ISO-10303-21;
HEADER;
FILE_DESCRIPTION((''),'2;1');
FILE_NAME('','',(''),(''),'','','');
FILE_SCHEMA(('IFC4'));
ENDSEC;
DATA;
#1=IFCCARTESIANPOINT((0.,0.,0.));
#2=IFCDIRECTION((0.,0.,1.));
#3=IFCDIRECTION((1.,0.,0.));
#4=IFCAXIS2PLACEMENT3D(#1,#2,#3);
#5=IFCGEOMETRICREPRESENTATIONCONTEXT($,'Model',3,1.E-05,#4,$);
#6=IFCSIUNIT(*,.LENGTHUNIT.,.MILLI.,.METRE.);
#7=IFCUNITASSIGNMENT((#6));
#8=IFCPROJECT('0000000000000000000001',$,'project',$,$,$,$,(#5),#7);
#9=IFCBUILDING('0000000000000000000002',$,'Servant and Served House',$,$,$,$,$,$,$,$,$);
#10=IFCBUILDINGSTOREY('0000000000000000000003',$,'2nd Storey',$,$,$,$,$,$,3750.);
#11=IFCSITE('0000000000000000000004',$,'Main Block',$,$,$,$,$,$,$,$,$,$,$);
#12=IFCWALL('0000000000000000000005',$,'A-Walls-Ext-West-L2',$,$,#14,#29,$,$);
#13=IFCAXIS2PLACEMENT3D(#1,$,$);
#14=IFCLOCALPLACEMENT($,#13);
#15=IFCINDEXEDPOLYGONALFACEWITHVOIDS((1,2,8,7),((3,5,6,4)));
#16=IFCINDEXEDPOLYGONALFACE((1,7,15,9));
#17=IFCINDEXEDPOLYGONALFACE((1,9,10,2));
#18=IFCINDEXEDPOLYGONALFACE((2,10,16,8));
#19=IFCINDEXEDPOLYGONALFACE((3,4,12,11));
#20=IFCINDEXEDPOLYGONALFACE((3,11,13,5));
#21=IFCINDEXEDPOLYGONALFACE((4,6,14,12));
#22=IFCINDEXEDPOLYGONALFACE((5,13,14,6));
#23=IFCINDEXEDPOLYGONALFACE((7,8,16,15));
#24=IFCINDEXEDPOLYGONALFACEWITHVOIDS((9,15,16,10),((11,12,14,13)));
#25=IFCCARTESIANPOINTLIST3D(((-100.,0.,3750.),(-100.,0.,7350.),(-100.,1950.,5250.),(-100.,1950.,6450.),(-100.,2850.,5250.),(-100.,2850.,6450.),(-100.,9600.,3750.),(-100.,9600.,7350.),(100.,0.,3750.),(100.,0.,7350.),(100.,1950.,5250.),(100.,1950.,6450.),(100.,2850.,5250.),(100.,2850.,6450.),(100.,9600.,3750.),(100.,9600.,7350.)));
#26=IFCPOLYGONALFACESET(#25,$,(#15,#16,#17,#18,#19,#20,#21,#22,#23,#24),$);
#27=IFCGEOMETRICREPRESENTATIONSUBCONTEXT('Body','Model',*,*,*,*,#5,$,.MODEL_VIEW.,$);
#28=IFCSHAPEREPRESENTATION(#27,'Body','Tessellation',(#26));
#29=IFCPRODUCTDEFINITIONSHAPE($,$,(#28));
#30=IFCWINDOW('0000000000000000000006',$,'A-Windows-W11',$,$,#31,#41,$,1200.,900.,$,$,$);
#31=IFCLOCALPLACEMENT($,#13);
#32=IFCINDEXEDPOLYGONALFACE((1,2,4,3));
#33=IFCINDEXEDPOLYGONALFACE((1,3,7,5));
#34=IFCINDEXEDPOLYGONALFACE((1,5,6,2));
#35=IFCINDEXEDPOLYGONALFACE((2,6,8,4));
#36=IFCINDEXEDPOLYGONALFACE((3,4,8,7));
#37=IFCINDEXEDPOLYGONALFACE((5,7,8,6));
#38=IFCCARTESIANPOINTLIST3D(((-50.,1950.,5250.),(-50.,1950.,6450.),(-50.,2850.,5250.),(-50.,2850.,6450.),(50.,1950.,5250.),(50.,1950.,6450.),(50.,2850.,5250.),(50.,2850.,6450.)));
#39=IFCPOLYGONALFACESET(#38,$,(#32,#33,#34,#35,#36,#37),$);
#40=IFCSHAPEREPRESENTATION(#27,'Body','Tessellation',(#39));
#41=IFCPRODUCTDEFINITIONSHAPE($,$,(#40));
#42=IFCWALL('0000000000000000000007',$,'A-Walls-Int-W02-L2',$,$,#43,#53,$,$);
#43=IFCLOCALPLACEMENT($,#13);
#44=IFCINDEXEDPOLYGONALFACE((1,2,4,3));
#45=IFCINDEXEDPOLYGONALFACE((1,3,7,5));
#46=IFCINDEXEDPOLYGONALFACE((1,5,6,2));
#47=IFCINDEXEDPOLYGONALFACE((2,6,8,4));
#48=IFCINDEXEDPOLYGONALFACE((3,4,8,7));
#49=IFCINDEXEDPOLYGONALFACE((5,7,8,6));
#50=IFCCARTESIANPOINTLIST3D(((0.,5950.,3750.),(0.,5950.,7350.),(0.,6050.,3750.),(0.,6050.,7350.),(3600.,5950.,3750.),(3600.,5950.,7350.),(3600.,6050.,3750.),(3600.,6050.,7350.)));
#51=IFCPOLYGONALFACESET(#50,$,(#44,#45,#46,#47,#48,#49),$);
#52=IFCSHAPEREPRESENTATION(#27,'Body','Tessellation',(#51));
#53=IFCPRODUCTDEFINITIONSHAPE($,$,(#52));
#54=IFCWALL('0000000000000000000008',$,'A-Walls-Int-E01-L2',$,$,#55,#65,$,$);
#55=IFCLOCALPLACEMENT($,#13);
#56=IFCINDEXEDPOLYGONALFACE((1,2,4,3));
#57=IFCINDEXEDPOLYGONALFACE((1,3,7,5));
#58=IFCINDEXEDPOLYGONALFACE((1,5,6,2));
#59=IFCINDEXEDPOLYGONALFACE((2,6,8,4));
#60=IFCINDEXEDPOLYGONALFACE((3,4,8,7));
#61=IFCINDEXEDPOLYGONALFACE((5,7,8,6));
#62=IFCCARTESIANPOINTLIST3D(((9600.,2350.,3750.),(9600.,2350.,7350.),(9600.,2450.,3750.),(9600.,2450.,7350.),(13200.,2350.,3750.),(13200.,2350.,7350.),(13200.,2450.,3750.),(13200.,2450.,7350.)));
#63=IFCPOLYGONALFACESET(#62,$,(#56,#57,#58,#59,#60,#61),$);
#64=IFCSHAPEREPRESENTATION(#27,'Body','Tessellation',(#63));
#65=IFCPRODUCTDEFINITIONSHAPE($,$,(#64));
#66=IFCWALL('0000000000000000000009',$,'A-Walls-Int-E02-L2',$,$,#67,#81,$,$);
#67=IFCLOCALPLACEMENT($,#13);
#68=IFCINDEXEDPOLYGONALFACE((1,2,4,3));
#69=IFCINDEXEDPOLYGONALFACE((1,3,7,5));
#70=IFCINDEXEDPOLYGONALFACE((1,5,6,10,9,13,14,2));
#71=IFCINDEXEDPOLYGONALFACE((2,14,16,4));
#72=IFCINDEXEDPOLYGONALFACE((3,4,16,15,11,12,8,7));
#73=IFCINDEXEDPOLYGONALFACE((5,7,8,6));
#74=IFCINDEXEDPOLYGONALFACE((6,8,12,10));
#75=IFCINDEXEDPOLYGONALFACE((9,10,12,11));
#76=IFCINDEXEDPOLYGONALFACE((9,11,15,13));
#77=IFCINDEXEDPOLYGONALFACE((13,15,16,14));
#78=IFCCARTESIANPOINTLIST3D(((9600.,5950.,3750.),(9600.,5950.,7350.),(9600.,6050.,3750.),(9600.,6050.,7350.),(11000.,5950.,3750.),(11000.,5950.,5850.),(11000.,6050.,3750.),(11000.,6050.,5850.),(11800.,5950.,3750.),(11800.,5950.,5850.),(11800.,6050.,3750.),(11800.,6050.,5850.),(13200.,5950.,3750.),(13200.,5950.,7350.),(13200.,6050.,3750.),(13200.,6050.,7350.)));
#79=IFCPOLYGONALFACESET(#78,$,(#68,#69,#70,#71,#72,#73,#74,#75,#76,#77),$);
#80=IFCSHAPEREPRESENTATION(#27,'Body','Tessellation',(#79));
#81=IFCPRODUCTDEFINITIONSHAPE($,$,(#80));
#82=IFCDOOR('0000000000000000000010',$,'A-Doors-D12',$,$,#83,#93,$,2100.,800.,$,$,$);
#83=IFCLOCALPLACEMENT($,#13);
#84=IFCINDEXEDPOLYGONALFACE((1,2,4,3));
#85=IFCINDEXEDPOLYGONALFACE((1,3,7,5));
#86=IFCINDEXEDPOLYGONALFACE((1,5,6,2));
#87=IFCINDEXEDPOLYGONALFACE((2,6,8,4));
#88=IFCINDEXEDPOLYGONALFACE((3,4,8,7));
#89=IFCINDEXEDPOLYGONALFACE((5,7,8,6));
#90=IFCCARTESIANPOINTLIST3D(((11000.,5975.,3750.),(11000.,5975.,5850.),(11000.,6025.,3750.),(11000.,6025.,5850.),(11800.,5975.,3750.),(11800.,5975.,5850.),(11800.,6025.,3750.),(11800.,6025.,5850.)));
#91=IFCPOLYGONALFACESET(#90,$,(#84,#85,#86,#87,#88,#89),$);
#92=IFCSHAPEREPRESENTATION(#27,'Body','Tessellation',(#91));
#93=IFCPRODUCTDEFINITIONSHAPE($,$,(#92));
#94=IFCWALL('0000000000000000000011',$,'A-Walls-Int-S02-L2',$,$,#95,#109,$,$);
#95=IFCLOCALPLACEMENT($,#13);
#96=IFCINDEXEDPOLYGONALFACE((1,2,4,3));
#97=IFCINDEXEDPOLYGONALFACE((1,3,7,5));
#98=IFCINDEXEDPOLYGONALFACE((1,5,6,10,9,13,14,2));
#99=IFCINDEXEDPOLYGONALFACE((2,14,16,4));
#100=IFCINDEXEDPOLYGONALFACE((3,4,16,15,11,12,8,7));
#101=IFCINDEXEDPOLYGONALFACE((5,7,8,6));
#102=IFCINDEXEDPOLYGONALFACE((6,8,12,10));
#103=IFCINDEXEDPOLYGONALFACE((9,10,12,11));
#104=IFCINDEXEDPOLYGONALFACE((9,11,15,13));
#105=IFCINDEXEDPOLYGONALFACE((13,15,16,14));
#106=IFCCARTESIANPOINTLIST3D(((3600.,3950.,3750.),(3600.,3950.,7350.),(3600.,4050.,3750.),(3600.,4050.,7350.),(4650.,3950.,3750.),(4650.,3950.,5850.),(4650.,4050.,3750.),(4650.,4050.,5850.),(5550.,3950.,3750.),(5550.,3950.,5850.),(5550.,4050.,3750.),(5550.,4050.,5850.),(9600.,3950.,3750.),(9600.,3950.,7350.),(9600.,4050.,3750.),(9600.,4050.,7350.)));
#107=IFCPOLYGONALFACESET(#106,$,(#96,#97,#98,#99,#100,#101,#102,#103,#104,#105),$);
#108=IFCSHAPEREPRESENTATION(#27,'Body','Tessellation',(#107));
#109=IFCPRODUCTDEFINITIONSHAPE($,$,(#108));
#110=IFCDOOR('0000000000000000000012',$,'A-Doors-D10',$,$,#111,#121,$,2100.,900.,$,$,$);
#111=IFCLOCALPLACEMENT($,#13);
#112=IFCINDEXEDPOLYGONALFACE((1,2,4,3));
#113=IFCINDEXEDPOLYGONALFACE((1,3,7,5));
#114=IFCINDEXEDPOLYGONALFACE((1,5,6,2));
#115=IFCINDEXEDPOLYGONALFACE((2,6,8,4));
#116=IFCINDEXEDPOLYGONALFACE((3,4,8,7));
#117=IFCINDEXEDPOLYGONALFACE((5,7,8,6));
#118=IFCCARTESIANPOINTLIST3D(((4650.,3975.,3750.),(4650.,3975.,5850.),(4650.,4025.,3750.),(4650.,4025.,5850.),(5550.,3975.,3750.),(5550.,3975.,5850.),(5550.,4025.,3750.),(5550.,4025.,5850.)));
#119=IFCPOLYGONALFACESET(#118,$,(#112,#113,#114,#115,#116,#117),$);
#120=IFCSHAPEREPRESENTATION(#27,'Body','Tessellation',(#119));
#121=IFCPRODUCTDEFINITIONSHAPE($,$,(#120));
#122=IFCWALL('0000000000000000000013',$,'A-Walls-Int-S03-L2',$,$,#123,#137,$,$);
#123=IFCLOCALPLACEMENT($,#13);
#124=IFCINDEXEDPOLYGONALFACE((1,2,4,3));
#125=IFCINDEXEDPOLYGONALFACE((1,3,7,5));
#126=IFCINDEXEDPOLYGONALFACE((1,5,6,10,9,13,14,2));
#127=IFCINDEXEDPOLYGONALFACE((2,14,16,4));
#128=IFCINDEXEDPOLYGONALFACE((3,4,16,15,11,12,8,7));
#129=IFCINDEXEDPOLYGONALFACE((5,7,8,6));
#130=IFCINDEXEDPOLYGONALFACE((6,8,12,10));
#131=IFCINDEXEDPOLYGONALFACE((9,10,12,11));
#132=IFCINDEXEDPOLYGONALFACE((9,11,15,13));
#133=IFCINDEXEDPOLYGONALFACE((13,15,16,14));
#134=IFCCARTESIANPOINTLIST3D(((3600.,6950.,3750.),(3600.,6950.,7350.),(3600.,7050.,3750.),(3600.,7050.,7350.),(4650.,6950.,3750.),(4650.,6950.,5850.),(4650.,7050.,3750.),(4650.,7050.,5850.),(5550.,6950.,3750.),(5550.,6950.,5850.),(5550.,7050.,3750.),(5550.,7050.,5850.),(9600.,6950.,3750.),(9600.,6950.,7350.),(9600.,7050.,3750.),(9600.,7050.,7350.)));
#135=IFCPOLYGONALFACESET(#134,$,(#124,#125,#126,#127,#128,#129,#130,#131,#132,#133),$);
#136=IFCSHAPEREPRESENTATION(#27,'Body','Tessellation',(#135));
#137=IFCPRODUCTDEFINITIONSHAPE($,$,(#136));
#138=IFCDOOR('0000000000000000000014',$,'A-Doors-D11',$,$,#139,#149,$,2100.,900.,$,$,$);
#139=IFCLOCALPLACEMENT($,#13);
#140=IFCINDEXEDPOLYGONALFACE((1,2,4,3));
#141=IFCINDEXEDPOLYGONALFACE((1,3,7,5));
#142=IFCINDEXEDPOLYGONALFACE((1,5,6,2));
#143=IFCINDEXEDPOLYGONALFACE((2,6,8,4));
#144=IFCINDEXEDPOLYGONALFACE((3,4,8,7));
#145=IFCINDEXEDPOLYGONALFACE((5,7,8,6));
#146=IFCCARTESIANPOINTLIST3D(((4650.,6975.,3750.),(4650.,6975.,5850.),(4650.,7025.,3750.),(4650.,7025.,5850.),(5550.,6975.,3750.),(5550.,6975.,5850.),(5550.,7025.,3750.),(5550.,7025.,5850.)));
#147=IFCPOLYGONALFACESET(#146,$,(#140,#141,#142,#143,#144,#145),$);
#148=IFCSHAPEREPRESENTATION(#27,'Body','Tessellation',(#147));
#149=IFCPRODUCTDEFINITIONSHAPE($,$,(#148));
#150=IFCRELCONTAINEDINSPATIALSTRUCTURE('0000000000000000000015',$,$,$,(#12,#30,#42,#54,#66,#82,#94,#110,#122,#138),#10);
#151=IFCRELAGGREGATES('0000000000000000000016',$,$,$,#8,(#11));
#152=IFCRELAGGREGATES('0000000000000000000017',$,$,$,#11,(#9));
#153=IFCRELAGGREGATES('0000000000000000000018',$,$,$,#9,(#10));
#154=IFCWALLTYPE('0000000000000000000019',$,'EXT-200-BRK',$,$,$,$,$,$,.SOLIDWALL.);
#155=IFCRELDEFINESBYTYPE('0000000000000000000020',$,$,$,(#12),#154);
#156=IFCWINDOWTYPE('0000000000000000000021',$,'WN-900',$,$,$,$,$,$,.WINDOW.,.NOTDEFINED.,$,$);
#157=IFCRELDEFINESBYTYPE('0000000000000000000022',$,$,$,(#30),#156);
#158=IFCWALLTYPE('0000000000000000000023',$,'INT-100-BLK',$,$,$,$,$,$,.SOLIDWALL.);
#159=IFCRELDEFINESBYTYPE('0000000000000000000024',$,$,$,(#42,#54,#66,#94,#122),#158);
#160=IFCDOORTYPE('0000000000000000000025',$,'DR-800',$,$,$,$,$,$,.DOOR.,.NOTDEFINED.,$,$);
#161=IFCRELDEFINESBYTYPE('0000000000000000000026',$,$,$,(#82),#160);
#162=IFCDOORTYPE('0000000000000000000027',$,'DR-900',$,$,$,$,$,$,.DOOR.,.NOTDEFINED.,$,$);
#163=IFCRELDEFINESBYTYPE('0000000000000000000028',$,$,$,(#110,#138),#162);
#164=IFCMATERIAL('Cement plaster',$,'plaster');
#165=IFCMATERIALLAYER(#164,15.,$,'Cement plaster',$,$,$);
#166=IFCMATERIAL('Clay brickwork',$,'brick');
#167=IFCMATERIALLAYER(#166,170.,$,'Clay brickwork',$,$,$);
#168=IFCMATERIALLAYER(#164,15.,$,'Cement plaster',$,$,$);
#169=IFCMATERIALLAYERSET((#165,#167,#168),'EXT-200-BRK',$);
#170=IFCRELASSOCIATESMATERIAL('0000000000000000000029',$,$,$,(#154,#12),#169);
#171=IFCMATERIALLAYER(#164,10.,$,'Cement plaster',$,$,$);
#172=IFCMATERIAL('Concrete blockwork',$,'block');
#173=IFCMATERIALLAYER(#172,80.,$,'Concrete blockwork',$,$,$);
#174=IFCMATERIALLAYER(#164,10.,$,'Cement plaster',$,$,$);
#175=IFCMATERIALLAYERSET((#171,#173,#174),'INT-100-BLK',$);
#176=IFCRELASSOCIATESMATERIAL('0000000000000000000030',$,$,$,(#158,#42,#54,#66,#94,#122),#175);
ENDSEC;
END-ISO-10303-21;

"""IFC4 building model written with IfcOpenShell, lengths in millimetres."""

from ifc_helpers import new_model, si_unit, frame, origin_with_axes, place, context, subcontext, project, spatial, indexed_curve, outline, extrude, material, layer, layer_set, layer_usage, type_object, element, fill, save


model = new_model("IFC4")

# Units and contexts
model_context = context("Model", 3, precision=1e-05, world=origin_with_axes())
body_context = subcontext(model_context, "Body", "Model", "MODEL_VIEW")
ifc_project = project(units=[si_unit("LENGTHUNIT", "METRE", prefix="MILLI")], contexts=[model_context])

# Site, building, storey
site = spatial("IfcSite", under=ifc_project, Name="Main Block")
building = spatial("IfcBuilding", under=site, Name="Servant and Served House")
storey = spatial("IfcBuildingStorey", under=building, Name="2nd Storey", Elevation=3750.0)

# Shared definitions
ifc_material_1 = material(Name="Cement plaster", Category="plaster")
ifc_layer_1 = layer(ifc_material_1, 15.0, Name="Cement plaster")
ifc_material_2 = material(Name="Clay brickwork", Category="brick")
ifc_layer_2 = layer(ifc_material_2, 170.0, Name="Clay brickwork")
ifc_layer_3 = layer(ifc_material_1, 15.0, Name="Cement plaster")
ifc_layer_set_1 = layer_set([ifc_layer_1, ifc_layer_2, ifc_layer_3], Name="EXT-200-BRK")
wall_type_1 = type_object("IfcWallType", Name="EXT-200-BRK", PredefinedType="SOLIDWALL", material=ifc_layer_set_1)

# Shared definitions
window_type_1 = type_object("IfcWindowType", Name="WN-900", PartitioningType="NOTDEFINED", PredefinedType="WINDOW")

# Wall, opening, window
ifc_layer_usage_1 = layer_usage(ifc_layer_set_1, "AXIS2", "POSITIVE", 0.0)
wall_1_placement = place(None, frame((-100.0, 9600.0, 3750.0), z_axis=(0.0, 0.0, 1.0), x_axis=(0.0, -1.0, 0.0)))
wall_1 = element("IfcWall", 1, at=wall_1_placement, inside=storey, type_object=wall_type_1, material=ifc_layer_usage_1, Name="A-Walls-Ext-West-L2", context=body_context, shape_type="SweptSolid", body=[
    extrude(outline(indexed_curve([(0.0, 0.0), (0.0, 200.0), (9600.0, 200.0), (9600.0, 0.0), (0.0, 0.0)], self_intersect=False)), origin_with_axes(), (0.0, 0.0, 1.0), 3600.0),
])
opening_1_placement = place(wall_1_placement, frame((7200.0, 100.0, 1500.0), z_axis=(0.0, 0.0, 1.0), x_axis=(1.0, 0.0, 0.0)))
opening_1 = element("IfcOpeningElement", 2, at=opening_1_placement, cuts=wall_1, PredefinedType="OPENING", context=body_context, shape_type="SweptSolid", body=[
    extrude(outline(indexed_curve([(-450.0, -150.0), (450.0, -150.0), (450.0, 150.0), (-450.0, 150.0)])), None, (0.0, 0.0, 1.0), 1200.0),
])
window_1_placement = place(None, frame((0.0, 2400.0, 5250.0), z_axis=(0.0, 0.0, 1.0), x_axis=(0.0, -1.0, 0.0)))
window_1 = element("IfcWindow", 3, at=window_1_placement, inside=storey, type_object=window_type_1, Name="A-Windows-W11", OverallHeight=1200.0, OverallWidth=900.0, context=body_context, shape_type="SweptSolid", body=[
    extrude(outline(indexed_curve([(-450.0, -50.0), (450.0, -50.0), (450.0, 50.0), (-450.0, 50.0)])), None, (0.0, 0.0, 1.0), 1200.0),
])
fill(opening_1, window_1)

# Walls
ifc_layer_4 = layer(ifc_material_1, 10.0, Name="Cement plaster")
ifc_material_3 = material(Name="Concrete blockwork", Category="block")
ifc_layer_5 = layer(ifc_material_3, 80.0, Name="Concrete blockwork")
ifc_layer_6 = layer(ifc_material_1, 10.0, Name="Cement plaster")
ifc_layer_set_2 = layer_set([ifc_layer_4, ifc_layer_5, ifc_layer_6], Name="INT-100-BLK")
ifc_layer_usage_2 = layer_usage(ifc_layer_set_2, "AXIS2", "POSITIVE", 0.0)
wall_type_2 = type_object("IfcWallType", Name="INT-100-BLK", PredefinedType="SOLIDWALL", material=ifc_layer_set_2)
wall_2_placement = place(None, frame((0.0, 5950.0, 3750.0), z_axis=(0.0, 0.0, 1.0), x_axis=(1.0, 0.0, 0.0)))
element("IfcWall", 4, at=wall_2_placement, inside=storey, type_object=wall_type_2, material=ifc_layer_usage_2, Name="A-Walls-Int-W02-L2", context=body_context, shape_type="SweptSolid", body=[
    extrude(outline(indexed_curve([(0.0, 0.0), (0.0, 100.0), (3600.0, 100.0), (3600.0, 0.0), (0.0, 0.0)], self_intersect=False)), origin_with_axes(), (0.0, 0.0, 1.0), 3600.0),
])
ifc_layer_usage_3 = layer_usage(ifc_layer_set_2, "AXIS2", "POSITIVE", 0.0)
wall_3_placement = place(None, frame((9600.0, 2350.0, 3750.0), z_axis=(0.0, 0.0, 1.0), x_axis=(1.0, 0.0, 0.0)))
element("IfcWall", 5, at=wall_3_placement, inside=storey, type_object=wall_type_2, material=ifc_layer_usage_3, Name="A-Walls-Int-E01-L2", context=body_context, shape_type="SweptSolid", body=[
    extrude(outline(indexed_curve([(0.0, 0.0), (0.0, 100.0), (3600.0, 100.0), (3600.0, 0.0), (0.0, 0.0)], self_intersect=False)), origin_with_axes(), (0.0, 0.0, 1.0), 3600.0),
])

# Walls, openings, doors
ifc_layer_usage_4 = layer_usage(ifc_layer_set_2, "AXIS2", "POSITIVE", 0.0)
wall_4_placement = place(None, frame((9600.0, 5950.0, 3750.0), z_axis=(0.0, 0.0, 1.0), x_axis=(1.0, 0.0, 0.0)))
wall_4 = element("IfcWall", 6, at=wall_4_placement, inside=storey, type_object=wall_type_2, material=ifc_layer_usage_4, Name="A-Walls-Int-E02-L2", context=body_context, shape_type="SweptSolid", body=[
    extrude(outline(indexed_curve([(0.0, 0.0), (0.0, 100.0), (3600.0, 100.0), (3600.0, 0.0), (0.0, 0.0)], self_intersect=False)), origin_with_axes(), (0.0, 0.0, 1.0), 3600.0),
])
opening_2_placement = place(wall_4_placement, frame((1800.0, 50.0, 0.0), z_axis=(0.0, 0.0, 1.0), x_axis=(1.0, 0.0, 0.0)))
opening_2 = element("IfcOpeningElement", 7, at=opening_2_placement, cuts=wall_4, PredefinedType="OPENING", context=body_context, shape_type="SweptSolid", body=[
    extrude(outline(indexed_curve([(-400.0, -100.0), (400.0, -100.0), (400.0, 100.0), (-400.0, 100.0)])), None, (0.0, 0.0, 1.0), 2100.0),
])
door_type_1 = type_object("IfcDoorType", Name="DR-800", OperationType="NOTDEFINED", PredefinedType="DOOR")
door_1_placement = place(None, frame((11400.0, 6000.0, 3750.0), z_axis=(0.0, 0.0, 1.0), x_axis=(1.0, 0.0, 0.0)))
door_1 = element("IfcDoor", 8, at=door_1_placement, inside=storey, type_object=door_type_1, Name="A-Doors-D12", OverallHeight=2100.0, OverallWidth=800.0, context=body_context, shape_type="SweptSolid", body=[
    extrude(outline(indexed_curve([(-400.0, -25.0), (400.0, -25.0), (400.0, 25.0), (-400.0, 25.0)])), None, (0.0, 0.0, 1.0), 2100.0),
])
fill(opening_2, door_1)
ifc_layer_usage_5 = layer_usage(ifc_layer_set_2, "AXIS2", "POSITIVE", 0.0)
wall_5_placement = place(None, frame((3600.0, 3950.0, 3750.0), z_axis=(0.0, 0.0, 1.0), x_axis=(1.0, 0.0, 0.0)))
wall_5 = element("IfcWall", 9, at=wall_5_placement, inside=storey, type_object=wall_type_2, material=ifc_layer_usage_5, Name="A-Walls-Int-S02-L2", context=body_context, shape_type="SweptSolid", body=[
    extrude(outline(indexed_curve([(0.0, 0.0), (0.0, 100.0), (6000.0, 100.0), (6000.0, 0.0), (0.0, 0.0)], self_intersect=False)), origin_with_axes(), (0.0, 0.0, 1.0), 3600.0),
])
opening_3_placement = place(wall_5_placement, frame((1500.0, 50.0, 0.0), z_axis=(0.0, 0.0, 1.0), x_axis=(1.0, 0.0, 0.0)))
opening_3 = element("IfcOpeningElement", 10, at=opening_3_placement, cuts=wall_5, PredefinedType="OPENING", context=body_context, shape_type="SweptSolid", body=[
    extrude(outline(indexed_curve([(-450.0, -100.0), (450.0, -100.0), (450.0, 100.0), (-450.0, 100.0)])), None, (0.0, 0.0, 1.0), 2100.0),
])
door_type_2 = type_object("IfcDoorType", Name="DR-900", OperationType="NOTDEFINED", PredefinedType="DOOR")
door_2_placement = place(None, frame((5100.0, 4000.0, 3750.0), z_axis=(0.0, 0.0, 1.0), x_axis=(1.0, 0.0, 0.0)))
door_2 = element("IfcDoor", 11, at=door_2_placement, inside=storey, type_object=door_type_2, Name="A-Doors-D10", OverallHeight=2100.0, OverallWidth=900.0, context=body_context, shape_type="SweptSolid", body=[
    extrude(outline(indexed_curve([(-450.0, -25.0), (450.0, -25.0), (450.0, 25.0), (-450.0, 25.0)])), None, (0.0, 0.0, 1.0), 2100.0),
])
fill(opening_3, door_2)
ifc_layer_usage_6 = layer_usage(ifc_layer_set_2, "AXIS2", "POSITIVE", 0.0)
wall_6_placement = place(None, frame((3600.0, 6950.0, 3750.0), z_axis=(0.0, 0.0, 1.0), x_axis=(1.0, 0.0, 0.0)))
wall_6 = element("IfcWall", 12, at=wall_6_placement, inside=storey, type_object=wall_type_2, material=ifc_layer_usage_6, Name="A-Walls-Int-S03-L2", context=body_context, shape_type="SweptSolid", body=[
    extrude(outline(indexed_curve([(0.0, 0.0), (0.0, 100.0), (6000.0, 100.0), (6000.0, 0.0), (0.0, 0.0)], self_intersect=False)), origin_with_axes(), (0.0, 0.0, 1.0), 3600.0),
])
opening_4_placement = place(wall_6_placement, frame((1500.0, 50.0, 0.0), z_axis=(0.0, 0.0, 1.0), x_axis=(1.0, 0.0, 0.0)))
opening_4 = element("IfcOpeningElement", 13, at=opening_4_placement, cuts=wall_6, PredefinedType="OPENING", context=body_context, shape_type="SweptSolid", body=[
    extrude(outline(indexed_curve([(-450.0, -100.0), (450.0, -100.0), (450.0, 100.0), (-450.0, 100.0)])), None, (0.0, 0.0, 1.0), 2100.0),
])
door_3_placement = place(None, frame((5100.0, 7000.0, 3750.0), z_axis=(0.0, 0.0, 1.0), x_axis=(1.0, 0.0, 0.0)))
door_3 = element("IfcDoor", 14, at=door_3_placement, inside=storey, type_object=door_type_2, Name="A-Doors-D11", OverallHeight=2100.0, OverallWidth=900.0, context=body_context, shape_type="SweptSolid", body=[
    extrude(outline(indexed_curve([(-450.0, -25.0), (450.0, -25.0), (450.0, 25.0), (-450.0, 25.0)])), None, (0.0, 0.0, 1.0), 2100.0),
])
fill(opening_4, door_3)

save(model, "model.ifc")
